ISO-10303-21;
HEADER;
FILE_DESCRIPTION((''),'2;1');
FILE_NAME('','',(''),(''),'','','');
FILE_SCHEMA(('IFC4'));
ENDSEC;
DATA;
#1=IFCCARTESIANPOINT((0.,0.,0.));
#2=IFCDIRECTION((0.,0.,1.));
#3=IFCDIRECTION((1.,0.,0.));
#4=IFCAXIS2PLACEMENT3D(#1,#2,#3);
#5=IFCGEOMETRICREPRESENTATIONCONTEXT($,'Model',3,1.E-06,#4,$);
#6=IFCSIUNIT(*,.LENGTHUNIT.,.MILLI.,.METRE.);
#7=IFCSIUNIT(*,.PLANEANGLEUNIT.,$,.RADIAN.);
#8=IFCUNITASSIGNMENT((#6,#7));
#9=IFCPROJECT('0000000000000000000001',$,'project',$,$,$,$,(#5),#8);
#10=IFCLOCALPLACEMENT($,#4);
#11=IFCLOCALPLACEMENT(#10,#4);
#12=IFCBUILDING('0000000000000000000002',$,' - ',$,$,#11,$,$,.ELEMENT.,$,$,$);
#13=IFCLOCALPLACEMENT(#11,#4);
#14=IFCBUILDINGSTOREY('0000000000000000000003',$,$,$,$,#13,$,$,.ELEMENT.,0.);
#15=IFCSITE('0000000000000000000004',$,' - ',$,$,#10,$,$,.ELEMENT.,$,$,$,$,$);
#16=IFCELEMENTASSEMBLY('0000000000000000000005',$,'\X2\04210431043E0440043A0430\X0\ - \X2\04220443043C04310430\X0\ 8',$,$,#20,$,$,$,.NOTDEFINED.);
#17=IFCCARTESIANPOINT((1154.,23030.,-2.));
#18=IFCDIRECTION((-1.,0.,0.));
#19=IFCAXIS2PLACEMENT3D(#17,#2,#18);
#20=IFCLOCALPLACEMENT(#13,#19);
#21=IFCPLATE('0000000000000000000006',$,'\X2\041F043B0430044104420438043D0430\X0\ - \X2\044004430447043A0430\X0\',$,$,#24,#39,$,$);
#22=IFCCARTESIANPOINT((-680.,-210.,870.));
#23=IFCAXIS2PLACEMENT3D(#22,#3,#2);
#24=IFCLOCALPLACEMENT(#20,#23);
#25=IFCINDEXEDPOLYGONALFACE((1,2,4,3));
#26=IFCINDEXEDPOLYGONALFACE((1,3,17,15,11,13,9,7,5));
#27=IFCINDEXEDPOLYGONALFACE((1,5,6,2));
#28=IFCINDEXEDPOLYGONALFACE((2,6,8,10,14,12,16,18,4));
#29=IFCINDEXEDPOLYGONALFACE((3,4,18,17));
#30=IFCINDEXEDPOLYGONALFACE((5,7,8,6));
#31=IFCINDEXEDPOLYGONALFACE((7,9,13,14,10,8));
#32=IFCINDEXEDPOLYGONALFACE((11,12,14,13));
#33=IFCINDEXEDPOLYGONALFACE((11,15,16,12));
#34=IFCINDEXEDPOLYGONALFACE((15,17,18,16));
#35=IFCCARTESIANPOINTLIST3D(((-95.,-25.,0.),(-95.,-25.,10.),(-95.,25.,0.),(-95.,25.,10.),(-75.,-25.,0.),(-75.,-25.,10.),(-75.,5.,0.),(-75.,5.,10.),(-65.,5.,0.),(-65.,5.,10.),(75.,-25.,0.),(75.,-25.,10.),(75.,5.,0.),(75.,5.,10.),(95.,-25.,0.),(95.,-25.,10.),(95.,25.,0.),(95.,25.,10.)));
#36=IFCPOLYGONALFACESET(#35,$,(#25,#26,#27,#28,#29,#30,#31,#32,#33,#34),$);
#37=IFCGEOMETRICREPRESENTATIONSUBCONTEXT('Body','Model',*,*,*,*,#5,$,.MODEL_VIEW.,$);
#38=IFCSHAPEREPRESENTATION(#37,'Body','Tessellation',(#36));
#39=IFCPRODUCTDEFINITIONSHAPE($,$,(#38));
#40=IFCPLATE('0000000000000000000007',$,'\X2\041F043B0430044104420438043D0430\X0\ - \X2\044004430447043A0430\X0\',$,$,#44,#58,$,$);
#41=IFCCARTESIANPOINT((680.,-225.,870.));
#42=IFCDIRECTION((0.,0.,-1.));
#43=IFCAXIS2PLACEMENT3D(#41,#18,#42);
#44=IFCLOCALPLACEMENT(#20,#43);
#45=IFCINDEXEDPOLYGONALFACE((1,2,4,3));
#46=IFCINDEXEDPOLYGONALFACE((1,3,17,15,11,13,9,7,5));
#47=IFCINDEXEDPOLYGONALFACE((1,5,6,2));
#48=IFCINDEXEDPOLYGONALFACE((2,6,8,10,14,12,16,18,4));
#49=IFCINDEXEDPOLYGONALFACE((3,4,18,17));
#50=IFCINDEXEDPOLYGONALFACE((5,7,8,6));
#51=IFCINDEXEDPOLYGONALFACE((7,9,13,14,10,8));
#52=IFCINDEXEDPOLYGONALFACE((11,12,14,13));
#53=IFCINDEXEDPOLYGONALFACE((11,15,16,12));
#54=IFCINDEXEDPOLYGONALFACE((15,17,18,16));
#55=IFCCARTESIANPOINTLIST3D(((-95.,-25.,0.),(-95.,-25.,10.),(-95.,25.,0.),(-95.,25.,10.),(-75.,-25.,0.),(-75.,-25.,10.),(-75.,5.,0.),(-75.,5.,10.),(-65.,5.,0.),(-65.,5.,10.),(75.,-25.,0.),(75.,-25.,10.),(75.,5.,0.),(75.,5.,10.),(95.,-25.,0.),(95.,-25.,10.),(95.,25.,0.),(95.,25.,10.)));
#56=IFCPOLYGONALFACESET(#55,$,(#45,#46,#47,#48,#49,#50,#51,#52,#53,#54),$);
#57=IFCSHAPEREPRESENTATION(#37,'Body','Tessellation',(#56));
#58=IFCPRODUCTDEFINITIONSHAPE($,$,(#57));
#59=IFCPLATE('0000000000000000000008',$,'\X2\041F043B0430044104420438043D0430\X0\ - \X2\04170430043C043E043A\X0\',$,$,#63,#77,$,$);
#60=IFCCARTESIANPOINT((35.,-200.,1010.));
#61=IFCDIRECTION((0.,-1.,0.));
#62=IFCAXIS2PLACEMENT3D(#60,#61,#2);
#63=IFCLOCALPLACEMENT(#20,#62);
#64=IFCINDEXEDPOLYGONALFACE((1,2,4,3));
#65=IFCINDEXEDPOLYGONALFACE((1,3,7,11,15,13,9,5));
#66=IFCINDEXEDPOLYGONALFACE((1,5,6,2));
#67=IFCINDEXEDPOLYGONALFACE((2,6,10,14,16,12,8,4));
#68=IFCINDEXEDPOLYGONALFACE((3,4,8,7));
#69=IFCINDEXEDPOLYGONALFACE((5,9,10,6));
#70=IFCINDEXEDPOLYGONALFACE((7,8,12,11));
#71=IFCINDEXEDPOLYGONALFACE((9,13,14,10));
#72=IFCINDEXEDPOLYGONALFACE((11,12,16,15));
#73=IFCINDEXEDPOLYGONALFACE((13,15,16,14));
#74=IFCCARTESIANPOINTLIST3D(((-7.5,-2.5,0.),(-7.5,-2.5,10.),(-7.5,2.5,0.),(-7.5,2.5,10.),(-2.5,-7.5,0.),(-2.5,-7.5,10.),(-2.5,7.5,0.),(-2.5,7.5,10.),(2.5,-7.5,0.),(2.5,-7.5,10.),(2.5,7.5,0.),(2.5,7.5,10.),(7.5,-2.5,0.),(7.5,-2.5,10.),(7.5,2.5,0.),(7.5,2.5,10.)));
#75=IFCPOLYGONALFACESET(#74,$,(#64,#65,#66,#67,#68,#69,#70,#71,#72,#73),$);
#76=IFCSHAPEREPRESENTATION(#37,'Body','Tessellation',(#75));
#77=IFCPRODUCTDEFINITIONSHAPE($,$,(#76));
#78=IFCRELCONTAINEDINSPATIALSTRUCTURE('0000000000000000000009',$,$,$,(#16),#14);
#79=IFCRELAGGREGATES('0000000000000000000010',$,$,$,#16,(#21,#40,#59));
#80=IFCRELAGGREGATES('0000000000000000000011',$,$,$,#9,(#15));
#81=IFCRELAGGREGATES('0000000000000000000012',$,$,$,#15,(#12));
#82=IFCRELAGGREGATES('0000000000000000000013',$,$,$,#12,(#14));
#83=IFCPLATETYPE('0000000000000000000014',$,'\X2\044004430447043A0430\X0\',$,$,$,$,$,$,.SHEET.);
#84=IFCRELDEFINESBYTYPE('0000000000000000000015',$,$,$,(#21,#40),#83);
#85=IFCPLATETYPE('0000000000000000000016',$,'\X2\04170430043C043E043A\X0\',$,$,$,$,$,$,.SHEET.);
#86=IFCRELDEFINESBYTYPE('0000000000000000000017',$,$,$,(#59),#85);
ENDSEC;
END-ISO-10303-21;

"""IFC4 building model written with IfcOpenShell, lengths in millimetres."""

from ifc_helpers import new_model, si_unit, frame, origin_with_axes, place, context, subcontext, project, spatial, line, indexed_curve, outline, extrude, source, transform, mapped, type_object, element, aggregate, save


model = new_model("IFC4")

# Units and contexts
model_context = context("Model", 3, precision=1e-06, world=origin_with_axes())
body_context = subcontext(model_context, "Body", "Model", "MODEL_VIEW")
ifc_project = project(units=[si_unit("LENGTHUNIT", "METRE", prefix="MILLI"), si_unit("PLANEANGLEUNIT", "RADIAN")], contexts=[model_context])

# Site, building, storey
site_placement = place(None, origin_with_axes())
site = spatial("IfcSite", under=ifc_project, at=site_placement, Name=" - ", CompositionType="ELEMENT")
building_placement = place(site_placement, origin_with_axes())
building = spatial("IfcBuilding", under=site, at=building_placement, Name=" - ", CompositionType="ELEMENT")
storey_placement = place(building_placement, origin_with_axes())
storey = spatial("IfcBuildingStorey", under=building, at=storey_placement, CompositionType="ELEMENT", Elevation=0.0)

# Shared definitions
plate_type_1 = type_object("IfcPlateType", Name="ручка", PredefinedType="SHEET")

# Element assembly, plate
assembly_1_placement = place(storey_placement, frame((1154.0, 23030.0, -2.0), z_axis=(0.0, 0.0, 1.0), x_axis=(-1.0, 0.0, 0.0)))
assembly_1 = element("IfcElementAssembly", 1, at=assembly_1_placement, inside=storey, Name="Сборка - Тумба 8", PredefinedType="NOTDEFINED")
shared_shape_1 = source(origin_with_axes(), body_context, "Body", "SweptSolid", [
    extrude(outline(indexed_curve([(-95.0, -25.0), (-75.0, -25.0), (-75.0, 5.0), (-65.0, 5.0), (75.0, 5.0), (75.0, -25.0), (95.0, -25.0), (95.0, 25.0), (-95.0, 25.0)], segments=[line(1, 2), line(2, 3), line(3, 4), line(4, 5), line(5, 6), line(6, 7), line(7, 8), line(8, 9), line(9, 1)])), origin_with_axes(), (0.0, 0.0, 1.0), 10.0),
])
plate_1_placement = place(assembly_1_placement, frame((-680.0, -210.0, 870.0), z_axis=(1.0, 0.0, 0.0), x_axis=(0.0, 0.0, 1.0)))
plate_1 = element("IfcPlate", 2, at=plate_1_placement, type_object=plate_type_1, Name="Пластина - ручка", context=body_context, shape_type="MappedRepresentation", body=[
    mapped(shared_shape_1, transform((0.0, 0.0, 0.0), x_axis=(1.0, 0.0, 0.0), y_axis=(0.0, 1.0, 0.0), z_axis=(0.0, 0.0, 1.0), scale=1.0)),
])

# Plates
shared_shape_2 = source(origin_with_axes(), body_context, "Body", "SweptSolid", [
    extrude(outline(indexed_curve([(-95.0, -25.0), (-75.0, -25.0), (-75.0, 5.0), (-65.0, 5.0), (75.0, 5.0), (75.0, -25.0), (95.0, -25.0), (95.0, 25.0), (-95.0, 25.0)], segments=[line(1, 2), line(2, 3), line(3, 4), line(4, 5), line(5, 6), line(6, 7), line(7, 8), line(8, 9), line(9, 1)])), origin_with_axes(), (0.0, 0.0, 1.0), 10.0),
])
plate_2_placement = place(assembly_1_placement, frame((680.0, -225.0, 870.0), z_axis=(-1.0, 0.0, 0.0), x_axis=(0.0, 0.0, -1.0)))
plate_2 = element("IfcPlate", 3, at=plate_2_placement, type_object=plate_type_1, Name="Пластина - ручка", context=body_context, shape_type="MappedRepresentation", body=[
    mapped(shared_shape_2, transform((0.0, 0.0, 0.0), x_axis=(1.0, 0.0, 0.0), y_axis=(0.0, 1.0, 0.0), z_axis=(0.0, 0.0, 1.0), scale=1.0)),
])
plate_type_2 = type_object("IfcPlateType", Name="Замок", PredefinedType="SHEET")
shared_shape_3 = source(origin_with_axes(), body_context, "Body", "SweptSolid", [
    extrude(outline(indexed_curve([(-2.5, 7.5), (-7.5, 2.5), (-7.5, -2.5), (-2.5, -7.5), (2.5, -7.5), (7.5, -2.5), (7.5, 2.5), (2.5, 7.5)], segments=[line(1, 2), line(2, 3), line(3, 4), line(4, 5), line(5, 6), line(6, 7), line(7, 8), line(8, 1)])), origin_with_axes(), (0.0, 0.0, 1.0), 10.0),
])
plate_3_placement = place(assembly_1_placement, frame((35.0, -200.0, 1010.0), z_axis=(0.0, -1.0, 0.0), x_axis=(0.0, 0.0, 1.0)))
plate_3 = element("IfcPlate", 4, at=plate_3_placement, type_object=plate_type_2, Name="Пластина - Замок", context=body_context, shape_type="MappedRepresentation", body=[
    mapped(shared_shape_3, transform((0.0, 0.0, 0.0), x_axis=(1.0, 0.0, 0.0), y_axis=(0.0, 1.0, 0.0), z_axis=(0.0, 0.0, 1.0), scale=1.0)),
])
aggregate(assembly_1, [plate_1, plate_2, plate_3])

save(model, "model.ifc")
